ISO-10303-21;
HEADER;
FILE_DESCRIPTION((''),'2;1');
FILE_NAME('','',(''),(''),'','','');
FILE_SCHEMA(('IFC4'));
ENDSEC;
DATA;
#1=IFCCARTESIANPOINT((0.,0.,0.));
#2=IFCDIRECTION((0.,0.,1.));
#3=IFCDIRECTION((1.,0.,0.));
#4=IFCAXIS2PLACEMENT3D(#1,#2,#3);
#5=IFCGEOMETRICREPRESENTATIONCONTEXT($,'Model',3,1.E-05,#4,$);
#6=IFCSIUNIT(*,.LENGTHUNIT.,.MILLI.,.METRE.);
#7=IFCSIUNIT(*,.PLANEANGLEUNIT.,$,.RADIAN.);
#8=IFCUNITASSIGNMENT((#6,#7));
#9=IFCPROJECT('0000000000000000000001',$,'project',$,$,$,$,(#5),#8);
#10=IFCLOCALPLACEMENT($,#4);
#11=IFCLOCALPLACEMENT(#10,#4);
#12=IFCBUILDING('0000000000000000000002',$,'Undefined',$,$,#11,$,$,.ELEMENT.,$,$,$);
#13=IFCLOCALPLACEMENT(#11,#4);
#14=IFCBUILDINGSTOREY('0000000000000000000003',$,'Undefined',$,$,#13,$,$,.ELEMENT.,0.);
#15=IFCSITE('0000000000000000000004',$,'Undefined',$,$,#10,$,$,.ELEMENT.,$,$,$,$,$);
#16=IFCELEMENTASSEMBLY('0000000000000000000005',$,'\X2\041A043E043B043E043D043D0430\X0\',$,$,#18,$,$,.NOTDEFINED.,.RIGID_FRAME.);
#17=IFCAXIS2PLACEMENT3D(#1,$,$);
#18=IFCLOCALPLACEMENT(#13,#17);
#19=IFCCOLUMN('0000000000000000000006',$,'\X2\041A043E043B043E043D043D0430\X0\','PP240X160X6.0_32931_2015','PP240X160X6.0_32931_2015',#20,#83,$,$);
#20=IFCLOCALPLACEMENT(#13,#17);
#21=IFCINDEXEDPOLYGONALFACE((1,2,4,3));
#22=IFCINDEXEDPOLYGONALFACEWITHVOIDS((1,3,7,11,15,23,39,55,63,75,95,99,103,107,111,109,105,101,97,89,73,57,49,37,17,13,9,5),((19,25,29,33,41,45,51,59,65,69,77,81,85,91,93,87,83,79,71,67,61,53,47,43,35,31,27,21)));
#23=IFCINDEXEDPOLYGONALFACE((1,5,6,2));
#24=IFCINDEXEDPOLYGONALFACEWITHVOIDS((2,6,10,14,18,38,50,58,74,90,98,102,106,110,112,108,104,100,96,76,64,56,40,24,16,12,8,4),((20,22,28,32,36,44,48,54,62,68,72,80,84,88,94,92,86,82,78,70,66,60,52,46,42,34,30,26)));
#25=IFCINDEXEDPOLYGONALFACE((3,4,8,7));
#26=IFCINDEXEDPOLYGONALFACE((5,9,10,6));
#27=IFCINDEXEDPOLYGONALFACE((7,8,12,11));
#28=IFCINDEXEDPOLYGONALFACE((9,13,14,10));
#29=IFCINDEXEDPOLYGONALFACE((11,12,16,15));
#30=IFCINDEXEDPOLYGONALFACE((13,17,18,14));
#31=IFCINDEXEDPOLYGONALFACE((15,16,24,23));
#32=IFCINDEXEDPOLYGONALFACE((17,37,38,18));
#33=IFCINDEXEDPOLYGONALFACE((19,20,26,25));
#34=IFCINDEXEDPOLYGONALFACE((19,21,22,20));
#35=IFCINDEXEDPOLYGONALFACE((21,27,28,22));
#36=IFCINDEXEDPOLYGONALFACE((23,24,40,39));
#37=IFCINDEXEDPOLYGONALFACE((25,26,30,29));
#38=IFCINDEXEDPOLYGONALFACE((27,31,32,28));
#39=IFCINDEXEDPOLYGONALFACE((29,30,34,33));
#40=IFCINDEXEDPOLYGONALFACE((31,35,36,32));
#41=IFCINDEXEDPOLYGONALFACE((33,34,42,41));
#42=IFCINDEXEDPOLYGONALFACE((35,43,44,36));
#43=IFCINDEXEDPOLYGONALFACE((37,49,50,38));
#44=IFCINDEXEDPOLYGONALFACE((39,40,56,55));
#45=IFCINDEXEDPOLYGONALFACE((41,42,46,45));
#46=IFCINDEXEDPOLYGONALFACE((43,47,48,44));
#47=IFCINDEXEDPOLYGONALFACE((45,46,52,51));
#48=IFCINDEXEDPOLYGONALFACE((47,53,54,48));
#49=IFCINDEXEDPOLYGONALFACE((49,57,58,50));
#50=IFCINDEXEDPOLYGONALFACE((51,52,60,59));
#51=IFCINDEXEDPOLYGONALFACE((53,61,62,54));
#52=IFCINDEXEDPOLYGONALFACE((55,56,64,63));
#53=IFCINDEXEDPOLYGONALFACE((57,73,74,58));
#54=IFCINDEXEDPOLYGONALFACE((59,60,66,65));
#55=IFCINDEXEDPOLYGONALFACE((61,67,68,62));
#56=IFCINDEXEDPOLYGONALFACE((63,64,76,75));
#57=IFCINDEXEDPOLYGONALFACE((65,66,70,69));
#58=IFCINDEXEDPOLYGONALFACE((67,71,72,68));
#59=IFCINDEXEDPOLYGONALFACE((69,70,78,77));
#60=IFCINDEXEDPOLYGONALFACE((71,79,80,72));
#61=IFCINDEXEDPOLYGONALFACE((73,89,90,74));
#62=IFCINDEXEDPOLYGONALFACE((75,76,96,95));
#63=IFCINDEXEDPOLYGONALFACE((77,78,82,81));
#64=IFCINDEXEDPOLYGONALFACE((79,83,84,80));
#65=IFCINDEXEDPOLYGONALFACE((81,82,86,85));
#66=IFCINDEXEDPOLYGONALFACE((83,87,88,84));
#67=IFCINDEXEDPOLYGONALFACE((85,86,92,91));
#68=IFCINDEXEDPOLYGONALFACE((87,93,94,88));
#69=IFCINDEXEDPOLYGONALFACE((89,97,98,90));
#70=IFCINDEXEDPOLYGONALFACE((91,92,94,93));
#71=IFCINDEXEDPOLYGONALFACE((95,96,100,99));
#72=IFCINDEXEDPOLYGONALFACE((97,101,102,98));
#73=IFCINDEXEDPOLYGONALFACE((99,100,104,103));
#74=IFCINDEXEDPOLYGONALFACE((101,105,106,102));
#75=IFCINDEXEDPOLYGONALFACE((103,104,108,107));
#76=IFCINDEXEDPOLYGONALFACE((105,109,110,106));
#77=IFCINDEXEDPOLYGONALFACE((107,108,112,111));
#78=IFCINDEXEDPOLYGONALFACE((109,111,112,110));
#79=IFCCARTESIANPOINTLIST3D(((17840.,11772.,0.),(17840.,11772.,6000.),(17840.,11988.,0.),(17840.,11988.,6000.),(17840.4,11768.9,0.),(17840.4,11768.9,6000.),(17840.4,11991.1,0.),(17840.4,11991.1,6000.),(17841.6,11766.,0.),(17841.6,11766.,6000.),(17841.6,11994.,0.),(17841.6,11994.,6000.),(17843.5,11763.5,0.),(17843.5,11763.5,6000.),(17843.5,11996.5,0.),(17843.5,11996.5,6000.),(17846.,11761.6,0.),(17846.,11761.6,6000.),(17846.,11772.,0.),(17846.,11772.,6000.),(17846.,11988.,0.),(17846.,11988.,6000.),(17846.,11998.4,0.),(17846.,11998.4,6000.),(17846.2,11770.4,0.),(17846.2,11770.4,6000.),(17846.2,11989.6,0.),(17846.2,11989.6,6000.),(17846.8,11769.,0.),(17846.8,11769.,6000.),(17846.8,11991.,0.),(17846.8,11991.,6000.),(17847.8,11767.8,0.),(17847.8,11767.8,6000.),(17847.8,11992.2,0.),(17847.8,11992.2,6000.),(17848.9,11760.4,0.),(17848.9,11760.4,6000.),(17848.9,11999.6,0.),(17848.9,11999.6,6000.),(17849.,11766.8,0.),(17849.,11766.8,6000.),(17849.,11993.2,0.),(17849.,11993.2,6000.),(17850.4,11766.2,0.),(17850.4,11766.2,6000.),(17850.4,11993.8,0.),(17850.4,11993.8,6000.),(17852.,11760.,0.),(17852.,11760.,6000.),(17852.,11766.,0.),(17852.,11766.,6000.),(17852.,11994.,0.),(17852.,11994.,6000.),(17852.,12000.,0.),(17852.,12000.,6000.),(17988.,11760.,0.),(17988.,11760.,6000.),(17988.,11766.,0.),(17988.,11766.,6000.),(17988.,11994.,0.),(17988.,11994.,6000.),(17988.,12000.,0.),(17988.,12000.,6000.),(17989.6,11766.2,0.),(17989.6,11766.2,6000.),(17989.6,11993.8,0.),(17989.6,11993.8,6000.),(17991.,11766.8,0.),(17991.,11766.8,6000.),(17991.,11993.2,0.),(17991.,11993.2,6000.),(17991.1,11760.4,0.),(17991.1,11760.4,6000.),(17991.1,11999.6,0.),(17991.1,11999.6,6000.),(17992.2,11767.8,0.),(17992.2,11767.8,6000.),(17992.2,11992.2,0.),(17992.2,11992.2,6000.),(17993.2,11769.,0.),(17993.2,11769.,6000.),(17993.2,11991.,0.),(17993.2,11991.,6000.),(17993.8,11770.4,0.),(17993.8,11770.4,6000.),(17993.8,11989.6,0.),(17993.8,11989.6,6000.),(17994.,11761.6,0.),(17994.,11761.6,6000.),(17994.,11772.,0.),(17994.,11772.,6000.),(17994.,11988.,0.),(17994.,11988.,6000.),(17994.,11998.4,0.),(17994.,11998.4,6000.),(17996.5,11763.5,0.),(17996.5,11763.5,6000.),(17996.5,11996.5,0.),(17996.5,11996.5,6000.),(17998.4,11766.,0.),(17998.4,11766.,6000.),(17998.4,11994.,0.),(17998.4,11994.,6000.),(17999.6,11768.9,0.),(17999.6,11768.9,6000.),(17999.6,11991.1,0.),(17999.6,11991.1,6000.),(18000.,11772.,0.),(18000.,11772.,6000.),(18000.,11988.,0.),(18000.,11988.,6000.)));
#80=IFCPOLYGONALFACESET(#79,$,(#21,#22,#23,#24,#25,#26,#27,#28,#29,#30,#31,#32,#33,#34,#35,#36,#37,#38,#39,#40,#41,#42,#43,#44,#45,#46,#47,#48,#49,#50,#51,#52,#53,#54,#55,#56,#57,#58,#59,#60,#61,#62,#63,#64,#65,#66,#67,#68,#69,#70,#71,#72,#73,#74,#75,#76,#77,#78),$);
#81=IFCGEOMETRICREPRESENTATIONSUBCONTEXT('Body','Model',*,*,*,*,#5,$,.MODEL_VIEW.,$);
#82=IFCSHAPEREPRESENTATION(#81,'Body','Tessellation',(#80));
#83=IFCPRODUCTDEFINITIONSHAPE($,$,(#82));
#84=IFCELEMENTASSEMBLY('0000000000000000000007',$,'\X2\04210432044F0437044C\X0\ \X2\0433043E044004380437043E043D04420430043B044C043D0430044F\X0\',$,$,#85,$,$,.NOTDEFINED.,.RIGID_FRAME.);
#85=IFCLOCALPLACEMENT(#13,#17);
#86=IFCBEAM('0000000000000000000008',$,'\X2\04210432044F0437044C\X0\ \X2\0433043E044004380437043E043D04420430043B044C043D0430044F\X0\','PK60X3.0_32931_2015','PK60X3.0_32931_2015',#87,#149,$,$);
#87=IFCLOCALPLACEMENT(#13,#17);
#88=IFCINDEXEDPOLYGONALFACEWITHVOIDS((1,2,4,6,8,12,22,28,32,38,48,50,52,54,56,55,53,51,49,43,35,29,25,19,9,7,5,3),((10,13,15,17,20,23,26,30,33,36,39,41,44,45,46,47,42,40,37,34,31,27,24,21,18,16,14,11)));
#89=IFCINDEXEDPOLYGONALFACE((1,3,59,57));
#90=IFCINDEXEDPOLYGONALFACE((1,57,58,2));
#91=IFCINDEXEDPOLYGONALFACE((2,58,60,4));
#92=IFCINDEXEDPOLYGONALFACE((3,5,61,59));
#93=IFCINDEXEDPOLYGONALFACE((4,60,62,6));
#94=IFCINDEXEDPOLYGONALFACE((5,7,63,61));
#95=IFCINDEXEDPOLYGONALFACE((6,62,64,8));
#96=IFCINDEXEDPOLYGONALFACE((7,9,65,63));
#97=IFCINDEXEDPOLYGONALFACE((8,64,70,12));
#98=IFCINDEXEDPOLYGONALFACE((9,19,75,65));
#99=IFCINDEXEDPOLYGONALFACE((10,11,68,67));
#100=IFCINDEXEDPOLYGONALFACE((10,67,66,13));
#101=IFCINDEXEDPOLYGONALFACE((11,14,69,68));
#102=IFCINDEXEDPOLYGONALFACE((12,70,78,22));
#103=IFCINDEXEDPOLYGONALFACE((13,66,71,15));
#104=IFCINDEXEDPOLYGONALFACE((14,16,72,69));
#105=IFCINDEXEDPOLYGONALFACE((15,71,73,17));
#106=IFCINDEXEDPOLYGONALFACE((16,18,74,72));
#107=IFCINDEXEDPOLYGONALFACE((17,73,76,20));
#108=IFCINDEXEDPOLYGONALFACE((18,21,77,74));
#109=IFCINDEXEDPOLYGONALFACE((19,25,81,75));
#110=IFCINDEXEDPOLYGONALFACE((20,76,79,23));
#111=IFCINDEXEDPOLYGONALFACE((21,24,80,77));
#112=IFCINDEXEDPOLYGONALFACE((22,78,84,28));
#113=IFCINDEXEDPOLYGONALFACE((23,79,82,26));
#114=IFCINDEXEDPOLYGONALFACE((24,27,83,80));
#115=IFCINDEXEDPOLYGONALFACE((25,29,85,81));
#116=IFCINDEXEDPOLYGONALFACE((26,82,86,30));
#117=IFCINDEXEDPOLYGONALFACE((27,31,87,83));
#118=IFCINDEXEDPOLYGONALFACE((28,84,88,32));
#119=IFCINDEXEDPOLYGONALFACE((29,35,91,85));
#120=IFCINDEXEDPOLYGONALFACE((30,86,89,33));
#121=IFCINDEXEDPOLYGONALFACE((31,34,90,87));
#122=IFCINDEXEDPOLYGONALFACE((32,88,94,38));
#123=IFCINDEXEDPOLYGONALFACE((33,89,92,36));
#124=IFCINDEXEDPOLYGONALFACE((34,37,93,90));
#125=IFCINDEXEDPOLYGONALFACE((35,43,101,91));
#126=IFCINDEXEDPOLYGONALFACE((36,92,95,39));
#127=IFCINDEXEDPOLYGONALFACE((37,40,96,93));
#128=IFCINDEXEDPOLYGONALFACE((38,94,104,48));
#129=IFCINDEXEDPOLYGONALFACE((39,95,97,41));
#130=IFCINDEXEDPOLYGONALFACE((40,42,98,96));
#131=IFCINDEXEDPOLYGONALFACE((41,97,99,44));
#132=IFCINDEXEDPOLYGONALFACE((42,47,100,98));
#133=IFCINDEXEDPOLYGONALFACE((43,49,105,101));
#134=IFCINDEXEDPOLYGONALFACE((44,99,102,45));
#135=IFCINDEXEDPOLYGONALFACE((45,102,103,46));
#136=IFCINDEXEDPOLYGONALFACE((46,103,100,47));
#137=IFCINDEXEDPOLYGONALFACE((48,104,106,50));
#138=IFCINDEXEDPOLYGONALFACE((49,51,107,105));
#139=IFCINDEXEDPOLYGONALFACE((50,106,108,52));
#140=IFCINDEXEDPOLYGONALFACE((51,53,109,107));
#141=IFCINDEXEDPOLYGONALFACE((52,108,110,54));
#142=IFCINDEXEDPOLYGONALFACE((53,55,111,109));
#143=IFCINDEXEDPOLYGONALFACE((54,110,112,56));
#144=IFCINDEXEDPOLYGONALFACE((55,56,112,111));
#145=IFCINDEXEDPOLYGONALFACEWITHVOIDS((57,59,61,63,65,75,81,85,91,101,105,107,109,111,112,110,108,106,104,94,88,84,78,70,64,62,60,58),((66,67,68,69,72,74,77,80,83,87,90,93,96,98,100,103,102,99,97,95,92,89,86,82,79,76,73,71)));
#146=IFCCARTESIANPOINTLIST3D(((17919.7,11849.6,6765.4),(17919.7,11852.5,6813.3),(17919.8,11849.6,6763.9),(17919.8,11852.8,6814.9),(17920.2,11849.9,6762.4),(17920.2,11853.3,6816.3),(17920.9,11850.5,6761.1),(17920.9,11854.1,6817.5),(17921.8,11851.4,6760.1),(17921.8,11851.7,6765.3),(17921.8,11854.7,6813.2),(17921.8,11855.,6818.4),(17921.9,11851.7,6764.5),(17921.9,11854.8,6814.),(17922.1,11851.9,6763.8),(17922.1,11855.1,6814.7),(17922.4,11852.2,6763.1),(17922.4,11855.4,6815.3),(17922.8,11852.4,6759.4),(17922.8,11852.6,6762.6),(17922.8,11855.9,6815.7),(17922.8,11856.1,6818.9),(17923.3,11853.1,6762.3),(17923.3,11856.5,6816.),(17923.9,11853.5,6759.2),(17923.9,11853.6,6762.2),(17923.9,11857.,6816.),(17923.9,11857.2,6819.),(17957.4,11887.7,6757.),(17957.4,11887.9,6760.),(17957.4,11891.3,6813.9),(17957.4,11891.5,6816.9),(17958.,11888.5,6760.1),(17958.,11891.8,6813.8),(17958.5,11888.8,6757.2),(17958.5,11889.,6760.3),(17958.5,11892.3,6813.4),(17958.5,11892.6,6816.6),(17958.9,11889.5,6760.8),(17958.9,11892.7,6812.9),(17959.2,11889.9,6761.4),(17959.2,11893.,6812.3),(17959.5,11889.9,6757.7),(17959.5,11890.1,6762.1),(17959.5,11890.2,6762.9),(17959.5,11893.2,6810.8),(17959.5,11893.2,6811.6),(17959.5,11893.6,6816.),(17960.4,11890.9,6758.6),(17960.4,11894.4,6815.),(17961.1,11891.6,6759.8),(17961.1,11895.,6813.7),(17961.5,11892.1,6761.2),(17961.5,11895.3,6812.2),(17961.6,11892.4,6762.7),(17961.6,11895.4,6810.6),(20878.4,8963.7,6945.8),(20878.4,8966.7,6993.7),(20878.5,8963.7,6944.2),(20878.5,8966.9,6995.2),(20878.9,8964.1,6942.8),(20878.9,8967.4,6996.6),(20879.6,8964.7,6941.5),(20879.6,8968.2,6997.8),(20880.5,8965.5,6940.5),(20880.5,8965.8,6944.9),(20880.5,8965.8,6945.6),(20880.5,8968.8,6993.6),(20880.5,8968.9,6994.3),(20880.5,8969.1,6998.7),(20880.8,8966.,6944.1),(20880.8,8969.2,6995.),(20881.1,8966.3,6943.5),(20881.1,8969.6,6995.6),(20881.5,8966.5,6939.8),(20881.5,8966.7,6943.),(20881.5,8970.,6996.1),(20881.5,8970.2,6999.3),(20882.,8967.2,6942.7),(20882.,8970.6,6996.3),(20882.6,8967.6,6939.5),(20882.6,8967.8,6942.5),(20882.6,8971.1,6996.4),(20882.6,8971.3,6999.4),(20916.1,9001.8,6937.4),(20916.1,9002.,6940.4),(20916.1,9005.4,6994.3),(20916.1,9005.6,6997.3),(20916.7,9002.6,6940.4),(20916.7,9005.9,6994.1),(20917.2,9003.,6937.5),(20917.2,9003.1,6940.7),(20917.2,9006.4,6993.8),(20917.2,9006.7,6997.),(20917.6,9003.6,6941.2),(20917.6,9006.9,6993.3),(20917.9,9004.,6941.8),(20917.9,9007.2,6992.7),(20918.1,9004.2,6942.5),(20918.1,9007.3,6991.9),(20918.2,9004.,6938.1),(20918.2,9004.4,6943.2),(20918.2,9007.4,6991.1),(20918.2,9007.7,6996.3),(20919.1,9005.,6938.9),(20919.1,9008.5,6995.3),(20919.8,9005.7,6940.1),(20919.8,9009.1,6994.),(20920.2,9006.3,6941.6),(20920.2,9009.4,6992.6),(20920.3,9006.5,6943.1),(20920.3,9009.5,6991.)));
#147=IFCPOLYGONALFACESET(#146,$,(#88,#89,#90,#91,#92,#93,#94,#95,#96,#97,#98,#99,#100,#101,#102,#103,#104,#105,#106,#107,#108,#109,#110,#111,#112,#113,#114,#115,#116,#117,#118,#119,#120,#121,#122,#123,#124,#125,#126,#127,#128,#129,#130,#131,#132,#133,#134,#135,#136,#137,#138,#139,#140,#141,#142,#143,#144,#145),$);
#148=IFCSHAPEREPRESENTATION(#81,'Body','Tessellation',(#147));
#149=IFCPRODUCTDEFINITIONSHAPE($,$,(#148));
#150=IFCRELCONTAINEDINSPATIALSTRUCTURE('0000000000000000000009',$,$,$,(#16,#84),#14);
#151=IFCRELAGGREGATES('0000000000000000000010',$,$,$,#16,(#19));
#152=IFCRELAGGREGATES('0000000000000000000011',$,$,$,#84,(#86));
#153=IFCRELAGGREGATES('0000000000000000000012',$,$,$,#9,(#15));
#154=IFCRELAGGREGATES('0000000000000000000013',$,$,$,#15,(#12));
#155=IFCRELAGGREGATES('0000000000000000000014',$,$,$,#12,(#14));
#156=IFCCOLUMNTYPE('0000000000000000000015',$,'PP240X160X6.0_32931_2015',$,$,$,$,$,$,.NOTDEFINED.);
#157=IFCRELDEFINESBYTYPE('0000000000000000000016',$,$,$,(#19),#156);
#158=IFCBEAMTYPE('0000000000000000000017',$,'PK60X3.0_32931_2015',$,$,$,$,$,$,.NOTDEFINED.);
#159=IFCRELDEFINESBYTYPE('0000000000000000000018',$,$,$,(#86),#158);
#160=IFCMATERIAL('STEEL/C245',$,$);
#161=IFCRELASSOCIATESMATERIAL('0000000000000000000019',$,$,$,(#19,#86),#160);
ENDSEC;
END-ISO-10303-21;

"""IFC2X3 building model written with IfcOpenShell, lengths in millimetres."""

from ifc_helpers import new_model, si_unit, frame, origin_with_axes, origin_2d_with_axis, place, context, subcontext, project, spatial, hollow_rectangle, extrude, material, type_object, element, aggregate, save


model = new_model("IFC2X3")

# Units and contexts
model_context = context("Model", 3, precision=1e-05, world=origin_with_axes())
body_context = subcontext(model_context, "Body", "Model", "MODEL_VIEW")
ifc_project = project(units=[si_unit("LENGTHUNIT", "METRE", prefix="MILLI"), si_unit("PLANEANGLEUNIT", "RADIAN")], contexts=[model_context])

# Site, building, storey
site_placement = place(None, origin_with_axes())
site = spatial("IfcSite", under=ifc_project, at=site_placement, Name="Undefined", CompositionType="ELEMENT")
building_placement = place(site_placement, origin_with_axes())
building = spatial("IfcBuilding", under=site, at=building_placement, Name="Undefined", CompositionType="ELEMENT")
storey_placement = place(building_placement, origin_with_axes())
storey = spatial("IfcBuildingStorey", under=building, at=storey_placement, Name="Undefined", CompositionType="ELEMENT", Elevation=0.0)

# Element assembly, column
assembly_1_placement = place(storey_placement, origin_with_axes())
assembly_1 = element("IfcElementAssembly", 1, at=assembly_1_placement, inside=storey, Name="Колонна", AssemblyPlace="NOTDEFINED", PredefinedType="RIGID_FRAME")
ifc_material = material(Name="STEEL/C245")
column_type = type_object("IfcColumnType", Name="PP240X160X6.0_32931_2015", PredefinedType="NOTDEFINED")
column_placement = place(assembly_1_placement, frame((17920.0, 11880.0, 0.0), z_axis=(0.0, 0.0, 1.0), x_axis=(0.0, -1.0, 0.0)))
column = element("IfcColumn", 2, at=column_placement, type_object=column_type, material=ifc_material, Name="Колонна", Description="PP240X160X6.0_32931_2015", ObjectType="PP240X160X6.0_32931_2015", context=body_context, shape_type="SweptSolid", body=[
    extrude(hollow_rectangle(XDim=160.0, YDim=240.0, WallThickness=6.0, InnerFilletRadius=6.0, OuterFilletRadius=12.0, at=origin_2d_with_axis()), frame((0.0, 0.0, 6000.0), z_axis=(0.0, 0.0, -1.0), x_axis=(0.0, 1.0, 0.0)), (0.0, 0.0, 1.0), 6000.0),
])
aggregate(assembly_1, [column])

# Element assembly, beam
assembly_2_placement = place(storey_placement, origin_with_axes())
assembly_2 = element("IfcElementAssembly", 3, at=assembly_2_placement, inside=storey, Name="Связь горизонтальная", AssemblyPlace="NOTDEFINED", PredefinedType="RIGID_FRAME")
beam_type_1 = type_object("IfcBeamType", Name="PK60X3.0_32931_2015", PredefinedType="NOTDEFINED")
beam_1_placement = place(assembly_2_placement, frame((17940.7, 11872.5, 6788.0), z_axis=(0.0, 0.062378, 0.998053), x_axis=(0.715179, -0.69758, 0.043599)))
beam_1 = element("IfcBeam", 4, at=beam_1_placement, type_object=beam_type_1, material=ifc_material, Name="Связь горизонтальная", Description="PK60X3.0_32931_2015", ObjectType="PK60X3.0_32931_2015", context=body_context, shape_type="SweptSolid", body=[
    extrude(hollow_rectangle(XDim=60.0, YDim=60.0, WallThickness=3.0, InnerFilletRadius=3.0, OuterFilletRadius=6.0, at=origin_2d_with_axis()), frame((4137.0, 0.0, 0.0), z_axis=(-1.0, 0.0, 0.0), x_axis=(0.0, -1.0, 0.0)), (0.0, 0.0, 1.0), 4137.0),
])
aggregate(assembly_2, [beam_1])

save(model, "model.ifc")
